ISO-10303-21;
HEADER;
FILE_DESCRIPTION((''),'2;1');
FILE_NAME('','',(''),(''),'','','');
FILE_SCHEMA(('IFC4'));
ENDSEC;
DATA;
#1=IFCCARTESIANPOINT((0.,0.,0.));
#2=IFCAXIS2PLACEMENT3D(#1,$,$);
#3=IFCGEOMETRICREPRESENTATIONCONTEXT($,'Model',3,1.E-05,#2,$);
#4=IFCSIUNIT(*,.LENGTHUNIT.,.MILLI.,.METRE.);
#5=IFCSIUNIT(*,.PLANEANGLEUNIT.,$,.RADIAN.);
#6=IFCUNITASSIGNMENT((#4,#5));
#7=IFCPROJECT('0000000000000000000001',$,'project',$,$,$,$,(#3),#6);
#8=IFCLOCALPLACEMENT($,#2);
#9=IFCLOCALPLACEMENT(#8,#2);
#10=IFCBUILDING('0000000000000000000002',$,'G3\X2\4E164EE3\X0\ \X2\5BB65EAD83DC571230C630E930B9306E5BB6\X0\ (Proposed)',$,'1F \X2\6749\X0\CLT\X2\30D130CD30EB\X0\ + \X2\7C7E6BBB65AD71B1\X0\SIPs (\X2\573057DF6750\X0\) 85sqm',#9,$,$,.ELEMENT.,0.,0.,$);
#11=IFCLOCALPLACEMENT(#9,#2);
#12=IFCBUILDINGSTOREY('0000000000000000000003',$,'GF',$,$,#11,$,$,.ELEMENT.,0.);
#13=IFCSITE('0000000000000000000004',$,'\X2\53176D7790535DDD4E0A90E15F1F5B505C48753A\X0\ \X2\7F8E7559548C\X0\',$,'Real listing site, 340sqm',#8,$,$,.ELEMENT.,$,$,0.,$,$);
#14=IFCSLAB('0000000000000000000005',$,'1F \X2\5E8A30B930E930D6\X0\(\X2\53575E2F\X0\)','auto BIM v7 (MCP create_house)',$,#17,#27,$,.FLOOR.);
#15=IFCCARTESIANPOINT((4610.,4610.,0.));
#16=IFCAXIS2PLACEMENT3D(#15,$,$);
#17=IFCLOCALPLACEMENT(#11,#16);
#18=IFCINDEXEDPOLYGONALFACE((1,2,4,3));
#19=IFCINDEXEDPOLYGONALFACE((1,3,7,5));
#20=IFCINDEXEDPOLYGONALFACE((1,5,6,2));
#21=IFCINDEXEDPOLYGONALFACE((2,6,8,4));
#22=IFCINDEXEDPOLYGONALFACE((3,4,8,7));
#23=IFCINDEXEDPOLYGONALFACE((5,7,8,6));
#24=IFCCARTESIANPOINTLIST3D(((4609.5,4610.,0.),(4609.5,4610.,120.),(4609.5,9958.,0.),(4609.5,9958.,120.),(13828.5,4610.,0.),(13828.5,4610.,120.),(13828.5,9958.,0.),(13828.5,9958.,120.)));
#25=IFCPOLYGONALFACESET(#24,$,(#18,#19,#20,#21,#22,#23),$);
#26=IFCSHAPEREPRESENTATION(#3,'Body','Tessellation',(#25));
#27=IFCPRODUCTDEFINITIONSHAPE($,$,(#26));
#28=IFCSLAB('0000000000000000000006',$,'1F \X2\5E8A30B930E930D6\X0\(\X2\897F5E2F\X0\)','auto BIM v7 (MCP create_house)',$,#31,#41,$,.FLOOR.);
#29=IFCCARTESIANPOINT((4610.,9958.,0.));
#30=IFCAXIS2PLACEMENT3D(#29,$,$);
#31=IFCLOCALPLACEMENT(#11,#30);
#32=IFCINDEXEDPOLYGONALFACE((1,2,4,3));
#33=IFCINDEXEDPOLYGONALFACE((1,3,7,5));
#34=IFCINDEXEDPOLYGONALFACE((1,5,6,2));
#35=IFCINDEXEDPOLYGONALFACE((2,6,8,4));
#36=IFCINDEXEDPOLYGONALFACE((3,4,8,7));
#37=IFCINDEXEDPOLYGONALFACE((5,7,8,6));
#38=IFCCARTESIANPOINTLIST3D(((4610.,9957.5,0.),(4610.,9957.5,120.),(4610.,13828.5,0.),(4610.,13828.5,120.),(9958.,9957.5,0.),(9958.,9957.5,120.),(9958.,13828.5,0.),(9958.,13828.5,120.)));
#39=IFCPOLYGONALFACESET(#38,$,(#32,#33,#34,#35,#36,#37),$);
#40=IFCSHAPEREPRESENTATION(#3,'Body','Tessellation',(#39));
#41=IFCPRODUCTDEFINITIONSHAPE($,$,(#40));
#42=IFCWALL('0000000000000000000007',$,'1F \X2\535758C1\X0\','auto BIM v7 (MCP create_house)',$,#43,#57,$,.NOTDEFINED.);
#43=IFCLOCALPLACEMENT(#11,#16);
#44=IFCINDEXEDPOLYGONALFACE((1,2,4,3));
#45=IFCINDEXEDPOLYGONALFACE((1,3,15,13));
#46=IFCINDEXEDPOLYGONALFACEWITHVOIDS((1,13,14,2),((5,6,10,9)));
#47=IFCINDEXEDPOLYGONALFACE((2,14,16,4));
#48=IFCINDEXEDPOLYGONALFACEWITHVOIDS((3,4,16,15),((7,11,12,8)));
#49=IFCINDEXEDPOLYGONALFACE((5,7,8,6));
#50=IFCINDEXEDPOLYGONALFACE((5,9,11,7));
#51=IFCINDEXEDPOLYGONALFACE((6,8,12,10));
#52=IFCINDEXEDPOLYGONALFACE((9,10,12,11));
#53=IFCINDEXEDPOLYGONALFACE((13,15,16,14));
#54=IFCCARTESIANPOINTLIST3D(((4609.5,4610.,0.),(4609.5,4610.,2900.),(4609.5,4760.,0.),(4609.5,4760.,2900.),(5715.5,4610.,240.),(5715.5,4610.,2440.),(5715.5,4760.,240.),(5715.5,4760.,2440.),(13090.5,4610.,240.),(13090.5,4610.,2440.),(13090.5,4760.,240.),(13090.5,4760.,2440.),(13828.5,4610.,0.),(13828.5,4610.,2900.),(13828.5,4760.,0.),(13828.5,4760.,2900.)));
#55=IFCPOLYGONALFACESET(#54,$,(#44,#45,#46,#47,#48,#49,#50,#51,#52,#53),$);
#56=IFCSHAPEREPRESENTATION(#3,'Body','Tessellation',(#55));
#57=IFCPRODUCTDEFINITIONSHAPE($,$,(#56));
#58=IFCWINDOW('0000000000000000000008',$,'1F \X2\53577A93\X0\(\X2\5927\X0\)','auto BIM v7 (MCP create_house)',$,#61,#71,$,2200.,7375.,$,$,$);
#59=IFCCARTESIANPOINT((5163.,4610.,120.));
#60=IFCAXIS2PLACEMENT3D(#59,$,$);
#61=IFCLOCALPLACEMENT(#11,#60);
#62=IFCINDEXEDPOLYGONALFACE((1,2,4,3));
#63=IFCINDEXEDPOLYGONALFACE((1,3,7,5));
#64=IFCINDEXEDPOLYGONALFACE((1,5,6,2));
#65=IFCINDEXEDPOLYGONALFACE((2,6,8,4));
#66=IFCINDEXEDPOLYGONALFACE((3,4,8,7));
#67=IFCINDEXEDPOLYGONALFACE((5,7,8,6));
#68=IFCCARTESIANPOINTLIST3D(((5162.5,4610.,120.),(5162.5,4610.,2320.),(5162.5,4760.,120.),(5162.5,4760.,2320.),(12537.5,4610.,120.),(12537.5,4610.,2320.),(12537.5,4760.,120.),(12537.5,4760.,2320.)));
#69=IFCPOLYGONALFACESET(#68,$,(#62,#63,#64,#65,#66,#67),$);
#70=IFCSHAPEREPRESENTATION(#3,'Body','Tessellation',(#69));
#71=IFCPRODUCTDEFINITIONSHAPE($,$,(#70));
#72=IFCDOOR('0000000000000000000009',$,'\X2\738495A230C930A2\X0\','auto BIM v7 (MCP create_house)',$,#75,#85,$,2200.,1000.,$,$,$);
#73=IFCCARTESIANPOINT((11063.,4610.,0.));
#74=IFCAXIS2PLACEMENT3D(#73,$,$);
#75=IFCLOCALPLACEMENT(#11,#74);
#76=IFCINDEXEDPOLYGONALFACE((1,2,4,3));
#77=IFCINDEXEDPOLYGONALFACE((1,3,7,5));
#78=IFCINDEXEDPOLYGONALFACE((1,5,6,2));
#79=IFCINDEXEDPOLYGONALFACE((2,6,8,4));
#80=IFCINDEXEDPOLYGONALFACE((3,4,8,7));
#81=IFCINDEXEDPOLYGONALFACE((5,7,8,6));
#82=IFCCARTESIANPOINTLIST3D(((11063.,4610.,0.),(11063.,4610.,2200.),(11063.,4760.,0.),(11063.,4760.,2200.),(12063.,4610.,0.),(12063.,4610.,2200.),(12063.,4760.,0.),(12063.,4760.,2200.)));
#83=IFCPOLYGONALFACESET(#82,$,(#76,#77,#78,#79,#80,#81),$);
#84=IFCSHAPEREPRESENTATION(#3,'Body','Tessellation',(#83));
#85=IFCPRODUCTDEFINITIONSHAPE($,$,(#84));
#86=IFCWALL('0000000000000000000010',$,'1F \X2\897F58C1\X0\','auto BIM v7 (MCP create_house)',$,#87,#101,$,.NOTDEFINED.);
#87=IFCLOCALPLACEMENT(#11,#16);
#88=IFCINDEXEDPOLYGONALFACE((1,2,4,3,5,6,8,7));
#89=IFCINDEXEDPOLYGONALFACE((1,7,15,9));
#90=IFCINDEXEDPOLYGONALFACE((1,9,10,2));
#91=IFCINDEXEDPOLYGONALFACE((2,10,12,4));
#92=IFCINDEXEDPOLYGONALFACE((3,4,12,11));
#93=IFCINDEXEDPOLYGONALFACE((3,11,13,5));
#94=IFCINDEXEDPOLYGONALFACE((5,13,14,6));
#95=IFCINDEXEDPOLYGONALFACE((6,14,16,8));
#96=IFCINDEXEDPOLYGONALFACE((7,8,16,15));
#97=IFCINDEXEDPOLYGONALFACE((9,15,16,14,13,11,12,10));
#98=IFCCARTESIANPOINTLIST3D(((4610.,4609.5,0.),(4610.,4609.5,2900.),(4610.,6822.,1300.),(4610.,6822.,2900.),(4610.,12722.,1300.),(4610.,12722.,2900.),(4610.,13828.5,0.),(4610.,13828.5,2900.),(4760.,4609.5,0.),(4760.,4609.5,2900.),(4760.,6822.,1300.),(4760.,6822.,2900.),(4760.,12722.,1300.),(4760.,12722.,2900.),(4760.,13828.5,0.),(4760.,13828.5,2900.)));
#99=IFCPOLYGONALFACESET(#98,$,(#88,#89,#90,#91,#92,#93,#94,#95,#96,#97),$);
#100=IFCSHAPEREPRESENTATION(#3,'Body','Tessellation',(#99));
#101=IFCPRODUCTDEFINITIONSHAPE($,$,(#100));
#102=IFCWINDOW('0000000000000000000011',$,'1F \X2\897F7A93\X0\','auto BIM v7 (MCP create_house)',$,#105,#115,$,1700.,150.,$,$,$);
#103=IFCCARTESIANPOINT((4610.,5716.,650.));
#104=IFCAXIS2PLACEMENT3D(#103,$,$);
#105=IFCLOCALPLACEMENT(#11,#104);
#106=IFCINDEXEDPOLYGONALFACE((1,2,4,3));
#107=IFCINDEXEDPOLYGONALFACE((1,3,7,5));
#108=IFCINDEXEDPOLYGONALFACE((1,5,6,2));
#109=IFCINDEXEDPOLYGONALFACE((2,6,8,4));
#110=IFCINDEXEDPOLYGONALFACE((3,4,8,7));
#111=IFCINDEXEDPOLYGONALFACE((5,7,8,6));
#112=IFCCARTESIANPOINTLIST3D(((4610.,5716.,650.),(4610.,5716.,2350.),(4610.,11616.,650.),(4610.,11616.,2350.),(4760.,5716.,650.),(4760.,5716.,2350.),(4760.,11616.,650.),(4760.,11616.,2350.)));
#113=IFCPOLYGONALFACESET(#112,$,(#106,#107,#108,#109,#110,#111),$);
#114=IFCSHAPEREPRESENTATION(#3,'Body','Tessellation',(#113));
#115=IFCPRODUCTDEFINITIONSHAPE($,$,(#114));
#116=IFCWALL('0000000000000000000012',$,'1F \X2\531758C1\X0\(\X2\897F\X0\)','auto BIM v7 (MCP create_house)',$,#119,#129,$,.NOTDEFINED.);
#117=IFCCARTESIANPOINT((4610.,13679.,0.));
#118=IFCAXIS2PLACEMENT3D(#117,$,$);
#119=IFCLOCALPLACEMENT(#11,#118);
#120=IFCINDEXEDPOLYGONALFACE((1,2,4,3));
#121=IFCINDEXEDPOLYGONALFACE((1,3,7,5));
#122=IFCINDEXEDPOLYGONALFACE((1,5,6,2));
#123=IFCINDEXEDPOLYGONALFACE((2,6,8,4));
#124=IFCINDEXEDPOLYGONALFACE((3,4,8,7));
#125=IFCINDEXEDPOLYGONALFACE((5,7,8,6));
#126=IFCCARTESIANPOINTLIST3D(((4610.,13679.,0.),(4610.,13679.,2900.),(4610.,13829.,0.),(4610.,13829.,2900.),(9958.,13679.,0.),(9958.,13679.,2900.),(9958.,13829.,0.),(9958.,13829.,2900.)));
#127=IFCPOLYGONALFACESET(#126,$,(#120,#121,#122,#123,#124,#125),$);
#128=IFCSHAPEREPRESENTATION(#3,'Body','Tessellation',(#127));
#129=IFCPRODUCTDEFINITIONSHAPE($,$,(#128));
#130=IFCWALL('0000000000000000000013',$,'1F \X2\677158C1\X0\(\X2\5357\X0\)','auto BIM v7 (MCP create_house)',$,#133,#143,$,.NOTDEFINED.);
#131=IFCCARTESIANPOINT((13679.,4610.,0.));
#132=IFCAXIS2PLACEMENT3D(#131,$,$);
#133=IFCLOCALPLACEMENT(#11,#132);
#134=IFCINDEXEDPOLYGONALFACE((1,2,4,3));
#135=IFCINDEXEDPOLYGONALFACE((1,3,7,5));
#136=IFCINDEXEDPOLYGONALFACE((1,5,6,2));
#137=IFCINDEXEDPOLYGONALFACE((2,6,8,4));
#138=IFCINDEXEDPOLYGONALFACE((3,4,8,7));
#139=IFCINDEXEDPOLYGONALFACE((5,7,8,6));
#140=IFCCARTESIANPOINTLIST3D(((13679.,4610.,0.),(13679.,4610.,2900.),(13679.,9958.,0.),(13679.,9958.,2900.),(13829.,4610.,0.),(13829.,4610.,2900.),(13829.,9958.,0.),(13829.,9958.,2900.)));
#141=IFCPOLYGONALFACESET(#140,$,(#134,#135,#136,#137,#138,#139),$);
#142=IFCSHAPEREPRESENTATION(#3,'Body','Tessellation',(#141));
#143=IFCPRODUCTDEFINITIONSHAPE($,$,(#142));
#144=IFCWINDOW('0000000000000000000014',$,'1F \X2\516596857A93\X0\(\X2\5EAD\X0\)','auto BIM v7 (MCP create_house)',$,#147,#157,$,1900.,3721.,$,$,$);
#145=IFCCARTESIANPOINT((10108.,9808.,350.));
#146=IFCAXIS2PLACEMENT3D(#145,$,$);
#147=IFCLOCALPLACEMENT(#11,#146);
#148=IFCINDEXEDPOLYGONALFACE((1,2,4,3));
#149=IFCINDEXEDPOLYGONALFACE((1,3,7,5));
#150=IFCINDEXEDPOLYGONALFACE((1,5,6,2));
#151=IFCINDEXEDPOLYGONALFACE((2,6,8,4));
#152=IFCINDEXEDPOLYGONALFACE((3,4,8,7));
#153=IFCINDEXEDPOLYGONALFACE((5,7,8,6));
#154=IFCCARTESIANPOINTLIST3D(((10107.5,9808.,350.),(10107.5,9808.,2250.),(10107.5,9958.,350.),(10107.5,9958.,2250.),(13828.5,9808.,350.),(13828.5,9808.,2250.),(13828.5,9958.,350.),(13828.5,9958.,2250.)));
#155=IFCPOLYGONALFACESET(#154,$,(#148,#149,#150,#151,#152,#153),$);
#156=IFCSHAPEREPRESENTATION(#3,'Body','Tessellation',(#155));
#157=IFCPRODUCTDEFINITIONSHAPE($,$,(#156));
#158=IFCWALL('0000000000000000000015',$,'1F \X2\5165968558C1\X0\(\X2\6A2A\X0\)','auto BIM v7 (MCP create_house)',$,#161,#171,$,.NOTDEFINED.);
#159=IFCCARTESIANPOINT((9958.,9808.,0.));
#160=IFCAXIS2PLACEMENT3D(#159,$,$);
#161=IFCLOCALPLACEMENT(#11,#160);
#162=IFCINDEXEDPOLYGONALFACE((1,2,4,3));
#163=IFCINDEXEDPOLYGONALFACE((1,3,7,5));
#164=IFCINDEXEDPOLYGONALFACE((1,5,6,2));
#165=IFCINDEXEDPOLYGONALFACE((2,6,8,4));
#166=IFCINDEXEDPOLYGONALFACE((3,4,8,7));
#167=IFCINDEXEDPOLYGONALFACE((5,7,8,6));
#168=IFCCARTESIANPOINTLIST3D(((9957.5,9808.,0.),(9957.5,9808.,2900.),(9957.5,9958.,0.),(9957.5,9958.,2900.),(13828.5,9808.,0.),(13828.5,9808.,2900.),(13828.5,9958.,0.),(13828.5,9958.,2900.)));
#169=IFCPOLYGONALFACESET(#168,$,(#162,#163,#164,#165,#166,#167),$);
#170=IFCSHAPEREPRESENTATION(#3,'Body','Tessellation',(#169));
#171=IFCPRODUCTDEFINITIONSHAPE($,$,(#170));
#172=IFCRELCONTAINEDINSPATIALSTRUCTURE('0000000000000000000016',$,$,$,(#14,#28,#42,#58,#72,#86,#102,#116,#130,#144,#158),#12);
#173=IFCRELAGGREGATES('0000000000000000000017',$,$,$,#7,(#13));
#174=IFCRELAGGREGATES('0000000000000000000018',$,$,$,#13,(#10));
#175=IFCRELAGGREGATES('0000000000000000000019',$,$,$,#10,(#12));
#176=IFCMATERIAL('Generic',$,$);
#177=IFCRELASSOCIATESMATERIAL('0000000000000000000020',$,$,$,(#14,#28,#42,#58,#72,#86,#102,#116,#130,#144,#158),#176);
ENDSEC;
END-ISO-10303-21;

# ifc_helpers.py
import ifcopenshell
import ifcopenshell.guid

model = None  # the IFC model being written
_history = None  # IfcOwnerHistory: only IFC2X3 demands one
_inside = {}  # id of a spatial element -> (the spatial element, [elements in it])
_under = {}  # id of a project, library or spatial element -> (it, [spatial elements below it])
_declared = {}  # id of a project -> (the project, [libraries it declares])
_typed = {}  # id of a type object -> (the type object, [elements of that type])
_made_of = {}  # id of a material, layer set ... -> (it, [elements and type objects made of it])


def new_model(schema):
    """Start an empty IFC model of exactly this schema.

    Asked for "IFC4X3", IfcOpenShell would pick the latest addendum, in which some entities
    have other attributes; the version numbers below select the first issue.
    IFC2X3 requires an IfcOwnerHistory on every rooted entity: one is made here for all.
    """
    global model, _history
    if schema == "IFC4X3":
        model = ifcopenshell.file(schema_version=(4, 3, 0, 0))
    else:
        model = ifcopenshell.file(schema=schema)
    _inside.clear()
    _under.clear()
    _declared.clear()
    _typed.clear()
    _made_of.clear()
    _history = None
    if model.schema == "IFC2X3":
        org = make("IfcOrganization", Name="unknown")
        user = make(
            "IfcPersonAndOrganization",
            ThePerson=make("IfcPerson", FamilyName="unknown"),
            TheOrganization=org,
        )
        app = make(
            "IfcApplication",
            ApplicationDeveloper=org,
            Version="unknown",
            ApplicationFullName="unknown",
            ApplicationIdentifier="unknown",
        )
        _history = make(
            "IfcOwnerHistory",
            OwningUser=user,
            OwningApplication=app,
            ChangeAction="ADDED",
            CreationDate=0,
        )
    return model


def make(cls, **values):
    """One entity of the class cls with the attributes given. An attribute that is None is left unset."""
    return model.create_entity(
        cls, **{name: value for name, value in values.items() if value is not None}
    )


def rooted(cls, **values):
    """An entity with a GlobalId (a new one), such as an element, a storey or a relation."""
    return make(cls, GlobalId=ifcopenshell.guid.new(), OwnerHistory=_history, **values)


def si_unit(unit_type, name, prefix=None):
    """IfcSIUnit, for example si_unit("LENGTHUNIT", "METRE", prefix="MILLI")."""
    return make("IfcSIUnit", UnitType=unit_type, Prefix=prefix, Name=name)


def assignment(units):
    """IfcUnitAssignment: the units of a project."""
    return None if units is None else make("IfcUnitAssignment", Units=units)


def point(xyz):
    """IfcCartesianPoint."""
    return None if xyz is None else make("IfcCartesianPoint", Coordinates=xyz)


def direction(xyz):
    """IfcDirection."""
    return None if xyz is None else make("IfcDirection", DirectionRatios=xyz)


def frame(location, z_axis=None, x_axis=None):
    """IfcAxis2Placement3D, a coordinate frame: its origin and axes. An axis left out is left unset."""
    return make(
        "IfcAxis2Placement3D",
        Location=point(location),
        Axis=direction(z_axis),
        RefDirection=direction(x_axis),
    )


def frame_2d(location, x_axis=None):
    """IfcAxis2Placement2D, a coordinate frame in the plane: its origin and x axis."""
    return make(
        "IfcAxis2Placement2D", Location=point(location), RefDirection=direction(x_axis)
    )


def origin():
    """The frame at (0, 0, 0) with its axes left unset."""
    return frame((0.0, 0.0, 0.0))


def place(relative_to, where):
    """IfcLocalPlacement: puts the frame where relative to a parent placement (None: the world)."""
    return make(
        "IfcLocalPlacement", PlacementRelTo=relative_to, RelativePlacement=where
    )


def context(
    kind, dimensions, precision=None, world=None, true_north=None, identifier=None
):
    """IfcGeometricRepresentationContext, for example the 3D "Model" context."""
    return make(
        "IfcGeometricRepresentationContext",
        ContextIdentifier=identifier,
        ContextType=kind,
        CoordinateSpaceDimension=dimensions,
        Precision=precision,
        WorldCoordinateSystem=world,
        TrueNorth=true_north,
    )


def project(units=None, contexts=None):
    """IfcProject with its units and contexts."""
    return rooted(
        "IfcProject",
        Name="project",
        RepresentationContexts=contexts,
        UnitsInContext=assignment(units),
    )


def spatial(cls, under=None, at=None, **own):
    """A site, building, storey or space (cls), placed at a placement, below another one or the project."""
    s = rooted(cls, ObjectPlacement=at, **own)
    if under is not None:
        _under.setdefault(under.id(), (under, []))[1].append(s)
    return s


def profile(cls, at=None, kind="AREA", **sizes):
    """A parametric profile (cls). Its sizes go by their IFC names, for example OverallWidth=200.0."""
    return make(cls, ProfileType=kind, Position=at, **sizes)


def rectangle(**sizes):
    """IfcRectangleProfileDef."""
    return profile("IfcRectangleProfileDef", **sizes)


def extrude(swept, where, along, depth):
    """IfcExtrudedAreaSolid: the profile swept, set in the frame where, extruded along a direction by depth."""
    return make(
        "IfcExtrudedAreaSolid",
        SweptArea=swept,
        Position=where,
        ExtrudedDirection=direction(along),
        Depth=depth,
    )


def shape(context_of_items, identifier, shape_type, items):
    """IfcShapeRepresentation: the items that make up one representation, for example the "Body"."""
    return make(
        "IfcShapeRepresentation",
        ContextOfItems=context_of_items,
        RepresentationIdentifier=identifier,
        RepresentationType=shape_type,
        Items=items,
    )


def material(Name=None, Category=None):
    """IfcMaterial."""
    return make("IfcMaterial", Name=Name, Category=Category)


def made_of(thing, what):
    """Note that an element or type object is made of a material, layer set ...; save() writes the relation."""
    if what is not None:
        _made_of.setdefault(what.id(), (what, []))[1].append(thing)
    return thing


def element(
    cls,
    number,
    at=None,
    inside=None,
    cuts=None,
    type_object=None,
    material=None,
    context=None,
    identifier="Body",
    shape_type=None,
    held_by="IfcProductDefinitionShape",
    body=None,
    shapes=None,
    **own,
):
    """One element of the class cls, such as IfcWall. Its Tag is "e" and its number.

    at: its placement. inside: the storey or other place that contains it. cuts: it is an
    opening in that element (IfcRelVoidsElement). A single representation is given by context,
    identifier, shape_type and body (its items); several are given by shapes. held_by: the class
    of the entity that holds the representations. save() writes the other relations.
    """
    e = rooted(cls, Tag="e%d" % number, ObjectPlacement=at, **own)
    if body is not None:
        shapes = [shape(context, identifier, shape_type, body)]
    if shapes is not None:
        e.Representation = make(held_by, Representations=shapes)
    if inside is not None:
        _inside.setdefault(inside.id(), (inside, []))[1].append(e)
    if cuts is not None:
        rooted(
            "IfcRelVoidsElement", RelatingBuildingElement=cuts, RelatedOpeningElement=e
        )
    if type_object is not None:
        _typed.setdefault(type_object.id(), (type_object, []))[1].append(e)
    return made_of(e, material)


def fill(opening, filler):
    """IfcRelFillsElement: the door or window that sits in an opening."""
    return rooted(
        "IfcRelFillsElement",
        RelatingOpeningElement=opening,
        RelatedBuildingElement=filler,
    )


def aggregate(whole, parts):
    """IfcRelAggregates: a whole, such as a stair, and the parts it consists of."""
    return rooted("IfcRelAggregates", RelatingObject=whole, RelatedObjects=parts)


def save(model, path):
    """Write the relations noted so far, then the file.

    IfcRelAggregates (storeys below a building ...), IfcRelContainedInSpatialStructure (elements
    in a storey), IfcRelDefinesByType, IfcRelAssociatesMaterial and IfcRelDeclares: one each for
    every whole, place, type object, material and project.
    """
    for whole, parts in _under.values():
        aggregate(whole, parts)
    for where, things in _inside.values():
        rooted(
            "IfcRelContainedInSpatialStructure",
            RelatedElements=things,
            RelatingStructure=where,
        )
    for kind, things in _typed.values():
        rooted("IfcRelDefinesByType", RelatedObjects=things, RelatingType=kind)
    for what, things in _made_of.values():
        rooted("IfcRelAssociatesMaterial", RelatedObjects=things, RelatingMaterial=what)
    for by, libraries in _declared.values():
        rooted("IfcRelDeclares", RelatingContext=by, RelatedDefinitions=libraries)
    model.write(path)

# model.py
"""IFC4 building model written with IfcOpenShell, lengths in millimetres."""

from ifc_helpers import new_model, si_unit, frame, frame_2d, origin, place, context, project, spatial, rectangle, extrude, material, element, fill, save


model = new_model("IFC4")

# Units and contexts
model_context = context("Model", 3, precision=1e-05, world=origin())
ifc_project = project(units=[si_unit("LENGTHUNIT", "METRE", prefix="MILLI"), si_unit("PLANEANGLEUNIT", "RADIAN")], contexts=[model_context])

# Site, building, storey
site_placement = place(None, origin())
site = spatial("IfcSite", under=ifc_project, at=site_placement, Name="北海道川上郡弟子屈町 美留和", ObjectType="Real listing site, 340sqm", CompositionType="ELEMENT", RefElevation=0.0)
building_placement = place(site_placement, origin())
building = spatial("IfcBuilding", under=site, at=building_placement, Name="G3世代 家庭菜園テラスの家 (Proposed)", ObjectType="1F 杉CLTパネル + 籾殻断熱SIPs (地域材) 85sqm", CompositionType="ELEMENT", ElevationOfRefHeight=0.0, ElevationOfTerrain=0.0)
storey_placement = place(building_placement, origin())
storey = spatial("IfcBuildingStorey", under=building, at=storey_placement, Name="GF", CompositionType="ELEMENT", Elevation=0.0)

# Slabs
ifc_material = material(Name="Generic")
slab_1_placement = place(storey_placement, frame((4610.0, 4610.0, 0.0)))
element("IfcSlab", 1, at=slab_1_placement, inside=storey, material=ifc_material, Name="1F 床スラブ(南帯)", Description="auto BIM v7 (MCP create_house)", PredefinedType="FLOOR", context=model_context, shape_type="SweptSolid", body=[
    extrude(rectangle(XDim=9219.0, YDim=5348.0, at=frame_2d((4609.0, 2674.0))), frame((4610.0, 4610.0, 0.0)), (0.0, 0.0, 1.0), 120.0),
])
slab_2_placement = place(storey_placement, frame((4610.0, 9958.0, 0.0)))
element("IfcSlab", 2, at=slab_2_placement, inside=storey, material=ifc_material, Name="1F 床スラブ(西帯)", Description="auto BIM v7 (MCP create_house)", PredefinedType="FLOOR", context=model_context, shape_type="SweptSolid", body=[
    extrude(rectangle(XDim=5348.0, YDim=3871.0, at=frame_2d((2674.0, 1935.0))), frame((4610.0, 9958.0, 0.0)), (0.0, 0.0, 1.0), 120.0),
])

# Wall, openings, window, door
wall_1_placement = place(storey_placement, frame((4610.0, 4610.0, 0.0)))
wall_1 = element("IfcWall", 3, at=wall_1_placement, inside=storey, material=ifc_material, Name="1F 南壁", Description="auto BIM v7 (MCP create_house)", PredefinedType="NOTDEFINED", context=model_context, shape_type="SweptSolid", body=[
    extrude(rectangle(XDim=9219.0, YDim=150.0, at=frame_2d((4609.0, 75.0))), frame((4610.0, 4610.0, 0.0)), (0.0, 0.0, 1.0), 2900.0),
])
opening_1_placement = place(storey_placement, frame((5163.0, 4610.0, 120.0)))
opening_1 = element("IfcOpeningElement", 4, at=opening_1_placement, cuts=wall_1, PredefinedType="NOTDEFINED", context=model_context, shape_type="SweptSolid", body=[
    extrude(rectangle(XDim=7375.0, YDim=150.0, at=frame_2d((3687.0, 75.0))), frame((5163.0, 4610.0, 120.0)), (0.0, 0.0, 1.0), 2200.0),
])
opening_2_placement = place(storey_placement, frame((11063.0, 4610.0, 0.0)))
opening_2 = element("IfcOpeningElement", 5, at=opening_2_placement, cuts=wall_1, PredefinedType="NOTDEFINED", context=model_context, shape_type="SweptSolid", body=[
    extrude(rectangle(XDim=1000.0, YDim=150.0, at=frame_2d((500.0, 75.0))), frame((11063.0, 4610.0, 0.0)), (0.0, 0.0, 1.0), 2200.0),
])
window_1_placement = place(storey_placement, frame((5163.0, 4610.0, 120.0)))
window_1 = element("IfcWindow", 6, at=window_1_placement, inside=storey, material=ifc_material, Name="1F 南窓(大)", Description="auto BIM v7 (MCP create_house)", OverallHeight=2200.0, OverallWidth=7375.0, context=model_context, shape_type="SweptSolid", body=[
    extrude(rectangle(XDim=7375.0, YDim=150.0, at=frame_2d((3687.0, 75.0))), frame((5163.0, 4610.0, 120.0)), (0.0, 0.0, 1.0), 2200.0),
])
fill(opening_1, window_1)
door_placement = place(storey_placement, frame((11063.0, 4610.0, 0.0)))
door = element("IfcDoor", 7, at=door_placement, inside=storey, material=ifc_material, Name="玄関ドア", Description="auto BIM v7 (MCP create_house)", OverallHeight=2200.0, OverallWidth=1000.0, context=model_context, shape_type="SweptSolid", body=[
    extrude(rectangle(XDim=1000.0, YDim=150.0, at=frame_2d((500.0, 75.0))), frame((11063.0, 4610.0, 0.0)), (0.0, 0.0, 1.0), 2200.0),
])
fill(opening_2, door)

# Wall, opening, window
wall_2_placement = place(storey_placement, frame((4610.0, 4610.0, 0.0)))
wall_2 = element("IfcWall", 8, at=wall_2_placement, inside=storey, material=ifc_material, Name="1F 西壁", Description="auto BIM v7 (MCP create_house)", PredefinedType="NOTDEFINED", context=model_context, shape_type="SweptSolid", body=[
    extrude(rectangle(XDim=150.0, YDim=9219.0, at=frame_2d((75.0, 4609.0))), frame((4610.0, 4610.0, 0.0)), (0.0, 0.0, 1.0), 2900.0),
])
opening_3_placement = place(storey_placement, frame((4610.0, 5716.0, 650.0)))
opening_3 = element("IfcOpeningElement", 9, at=opening_3_placement, cuts=wall_2, PredefinedType="NOTDEFINED", context=model_context, shape_type="SweptSolid", body=[
    extrude(rectangle(XDim=150.0, YDim=5900.0, at=frame_2d((75.0, 2950.0))), frame((4610.0, 5716.0, 650.0)), (0.0, 0.0, 1.0), 1700.0),
])
window_2_placement = place(storey_placement, frame((4610.0, 5716.0, 650.0)))
window_2 = element("IfcWindow", 10, at=window_2_placement, inside=storey, material=ifc_material, Name="1F 西窓", Description="auto BIM v7 (MCP create_house)", OverallHeight=1700.0, OverallWidth=150.0, context=model_context, shape_type="SweptSolid", body=[
    extrude(rectangle(XDim=150.0, YDim=5900.0, at=frame_2d((75.0, 2950.0))), frame((4610.0, 5716.0, 650.0)), (0.0, 0.0, 1.0), 1700.0),
])
fill(opening_3, window_2)

# Wall
wall_3_placement = place(storey_placement, frame((4610.0, 13679.0, 0.0)))
element("IfcWall", 11, at=wall_3_placement, inside=storey, material=ifc_material, Name="1F 北壁(西)", Description="auto BIM v7 (MCP create_house)", PredefinedType="NOTDEFINED", context=model_context, shape_type="SweptSolid", body=[
    extrude(rectangle(XDim=5348.0, YDim=150.0, at=frame_2d((2674.0, 75.0))), frame((4610.0, 13679.0, 0.0)), (0.0, 0.0, 1.0), 2900.0),
])

# Wall, opening, window
wall_4_placement = place(storey_placement, frame((13679.0, 4610.0, 0.0)))
wall_4 = element("IfcWall", 12, at=wall_4_placement, inside=storey, material=ifc_material, Name="1F 東壁(南)", Description="auto BIM v7 (MCP create_house)", PredefinedType="NOTDEFINED", context=model_context, shape_type="SweptSolid", body=[
    extrude(rectangle(XDim=150.0, YDim=5348.0, at=frame_2d((75.0, 2674.0))), frame((13679.0, 4610.0, 0.0)), (0.0, 0.0, 1.0), 2900.0),
])
opening_4_placement = place(storey_placement, frame((10108.0, 9808.0, 350.0)))
opening_4 = element("IfcOpeningElement", 13, at=opening_4_placement, cuts=wall_4, PredefinedType="NOTDEFINED", context=model_context, shape_type="SweptSolid", body=[
    extrude(rectangle(XDim=3721.0, YDim=150.0, at=frame_2d((1860.0, 75.0))), frame((10108.0, 9808.0, 350.0)), (0.0, 0.0, 1.0), 1900.0),
])
window_3_placement = place(storey_placement, frame((10108.0, 9808.0, 350.0)))
window_3 = element("IfcWindow", 14, at=window_3_placement, inside=storey, material=ifc_material, Name="1F 入隅窓(庭)", Description="auto BIM v7 (MCP create_house)", OverallHeight=1900.0, OverallWidth=3721.0, context=model_context, shape_type="SweptSolid", body=[
    extrude(rectangle(XDim=3721.0, YDim=150.0, at=frame_2d((1860.0, 75.0))), frame((10108.0, 9808.0, 350.0)), (0.0, 0.0, 1.0), 1900.0),
])
fill(opening_4, window_3)

# Wall
wall_5_placement = place(storey_placement, frame((9958.0, 9808.0, 0.0)))
element("IfcWall", 15, at=wall_5_placement, inside=storey, material=ifc_material, Name="1F 入隅壁(横)", Description="auto BIM v7 (MCP create_house)", PredefinedType="NOTDEFINED", context=model_context, shape_type="SweptSolid", body=[
    extrude(rectangle(XDim=3871.0, YDim=150.0, at=frame_2d((1935.0, 75.0))), frame((9958.0, 9808.0, 0.0)), (0.0, 0.0, 1.0), 2900.0),
])

save(model, "model.ifc")
